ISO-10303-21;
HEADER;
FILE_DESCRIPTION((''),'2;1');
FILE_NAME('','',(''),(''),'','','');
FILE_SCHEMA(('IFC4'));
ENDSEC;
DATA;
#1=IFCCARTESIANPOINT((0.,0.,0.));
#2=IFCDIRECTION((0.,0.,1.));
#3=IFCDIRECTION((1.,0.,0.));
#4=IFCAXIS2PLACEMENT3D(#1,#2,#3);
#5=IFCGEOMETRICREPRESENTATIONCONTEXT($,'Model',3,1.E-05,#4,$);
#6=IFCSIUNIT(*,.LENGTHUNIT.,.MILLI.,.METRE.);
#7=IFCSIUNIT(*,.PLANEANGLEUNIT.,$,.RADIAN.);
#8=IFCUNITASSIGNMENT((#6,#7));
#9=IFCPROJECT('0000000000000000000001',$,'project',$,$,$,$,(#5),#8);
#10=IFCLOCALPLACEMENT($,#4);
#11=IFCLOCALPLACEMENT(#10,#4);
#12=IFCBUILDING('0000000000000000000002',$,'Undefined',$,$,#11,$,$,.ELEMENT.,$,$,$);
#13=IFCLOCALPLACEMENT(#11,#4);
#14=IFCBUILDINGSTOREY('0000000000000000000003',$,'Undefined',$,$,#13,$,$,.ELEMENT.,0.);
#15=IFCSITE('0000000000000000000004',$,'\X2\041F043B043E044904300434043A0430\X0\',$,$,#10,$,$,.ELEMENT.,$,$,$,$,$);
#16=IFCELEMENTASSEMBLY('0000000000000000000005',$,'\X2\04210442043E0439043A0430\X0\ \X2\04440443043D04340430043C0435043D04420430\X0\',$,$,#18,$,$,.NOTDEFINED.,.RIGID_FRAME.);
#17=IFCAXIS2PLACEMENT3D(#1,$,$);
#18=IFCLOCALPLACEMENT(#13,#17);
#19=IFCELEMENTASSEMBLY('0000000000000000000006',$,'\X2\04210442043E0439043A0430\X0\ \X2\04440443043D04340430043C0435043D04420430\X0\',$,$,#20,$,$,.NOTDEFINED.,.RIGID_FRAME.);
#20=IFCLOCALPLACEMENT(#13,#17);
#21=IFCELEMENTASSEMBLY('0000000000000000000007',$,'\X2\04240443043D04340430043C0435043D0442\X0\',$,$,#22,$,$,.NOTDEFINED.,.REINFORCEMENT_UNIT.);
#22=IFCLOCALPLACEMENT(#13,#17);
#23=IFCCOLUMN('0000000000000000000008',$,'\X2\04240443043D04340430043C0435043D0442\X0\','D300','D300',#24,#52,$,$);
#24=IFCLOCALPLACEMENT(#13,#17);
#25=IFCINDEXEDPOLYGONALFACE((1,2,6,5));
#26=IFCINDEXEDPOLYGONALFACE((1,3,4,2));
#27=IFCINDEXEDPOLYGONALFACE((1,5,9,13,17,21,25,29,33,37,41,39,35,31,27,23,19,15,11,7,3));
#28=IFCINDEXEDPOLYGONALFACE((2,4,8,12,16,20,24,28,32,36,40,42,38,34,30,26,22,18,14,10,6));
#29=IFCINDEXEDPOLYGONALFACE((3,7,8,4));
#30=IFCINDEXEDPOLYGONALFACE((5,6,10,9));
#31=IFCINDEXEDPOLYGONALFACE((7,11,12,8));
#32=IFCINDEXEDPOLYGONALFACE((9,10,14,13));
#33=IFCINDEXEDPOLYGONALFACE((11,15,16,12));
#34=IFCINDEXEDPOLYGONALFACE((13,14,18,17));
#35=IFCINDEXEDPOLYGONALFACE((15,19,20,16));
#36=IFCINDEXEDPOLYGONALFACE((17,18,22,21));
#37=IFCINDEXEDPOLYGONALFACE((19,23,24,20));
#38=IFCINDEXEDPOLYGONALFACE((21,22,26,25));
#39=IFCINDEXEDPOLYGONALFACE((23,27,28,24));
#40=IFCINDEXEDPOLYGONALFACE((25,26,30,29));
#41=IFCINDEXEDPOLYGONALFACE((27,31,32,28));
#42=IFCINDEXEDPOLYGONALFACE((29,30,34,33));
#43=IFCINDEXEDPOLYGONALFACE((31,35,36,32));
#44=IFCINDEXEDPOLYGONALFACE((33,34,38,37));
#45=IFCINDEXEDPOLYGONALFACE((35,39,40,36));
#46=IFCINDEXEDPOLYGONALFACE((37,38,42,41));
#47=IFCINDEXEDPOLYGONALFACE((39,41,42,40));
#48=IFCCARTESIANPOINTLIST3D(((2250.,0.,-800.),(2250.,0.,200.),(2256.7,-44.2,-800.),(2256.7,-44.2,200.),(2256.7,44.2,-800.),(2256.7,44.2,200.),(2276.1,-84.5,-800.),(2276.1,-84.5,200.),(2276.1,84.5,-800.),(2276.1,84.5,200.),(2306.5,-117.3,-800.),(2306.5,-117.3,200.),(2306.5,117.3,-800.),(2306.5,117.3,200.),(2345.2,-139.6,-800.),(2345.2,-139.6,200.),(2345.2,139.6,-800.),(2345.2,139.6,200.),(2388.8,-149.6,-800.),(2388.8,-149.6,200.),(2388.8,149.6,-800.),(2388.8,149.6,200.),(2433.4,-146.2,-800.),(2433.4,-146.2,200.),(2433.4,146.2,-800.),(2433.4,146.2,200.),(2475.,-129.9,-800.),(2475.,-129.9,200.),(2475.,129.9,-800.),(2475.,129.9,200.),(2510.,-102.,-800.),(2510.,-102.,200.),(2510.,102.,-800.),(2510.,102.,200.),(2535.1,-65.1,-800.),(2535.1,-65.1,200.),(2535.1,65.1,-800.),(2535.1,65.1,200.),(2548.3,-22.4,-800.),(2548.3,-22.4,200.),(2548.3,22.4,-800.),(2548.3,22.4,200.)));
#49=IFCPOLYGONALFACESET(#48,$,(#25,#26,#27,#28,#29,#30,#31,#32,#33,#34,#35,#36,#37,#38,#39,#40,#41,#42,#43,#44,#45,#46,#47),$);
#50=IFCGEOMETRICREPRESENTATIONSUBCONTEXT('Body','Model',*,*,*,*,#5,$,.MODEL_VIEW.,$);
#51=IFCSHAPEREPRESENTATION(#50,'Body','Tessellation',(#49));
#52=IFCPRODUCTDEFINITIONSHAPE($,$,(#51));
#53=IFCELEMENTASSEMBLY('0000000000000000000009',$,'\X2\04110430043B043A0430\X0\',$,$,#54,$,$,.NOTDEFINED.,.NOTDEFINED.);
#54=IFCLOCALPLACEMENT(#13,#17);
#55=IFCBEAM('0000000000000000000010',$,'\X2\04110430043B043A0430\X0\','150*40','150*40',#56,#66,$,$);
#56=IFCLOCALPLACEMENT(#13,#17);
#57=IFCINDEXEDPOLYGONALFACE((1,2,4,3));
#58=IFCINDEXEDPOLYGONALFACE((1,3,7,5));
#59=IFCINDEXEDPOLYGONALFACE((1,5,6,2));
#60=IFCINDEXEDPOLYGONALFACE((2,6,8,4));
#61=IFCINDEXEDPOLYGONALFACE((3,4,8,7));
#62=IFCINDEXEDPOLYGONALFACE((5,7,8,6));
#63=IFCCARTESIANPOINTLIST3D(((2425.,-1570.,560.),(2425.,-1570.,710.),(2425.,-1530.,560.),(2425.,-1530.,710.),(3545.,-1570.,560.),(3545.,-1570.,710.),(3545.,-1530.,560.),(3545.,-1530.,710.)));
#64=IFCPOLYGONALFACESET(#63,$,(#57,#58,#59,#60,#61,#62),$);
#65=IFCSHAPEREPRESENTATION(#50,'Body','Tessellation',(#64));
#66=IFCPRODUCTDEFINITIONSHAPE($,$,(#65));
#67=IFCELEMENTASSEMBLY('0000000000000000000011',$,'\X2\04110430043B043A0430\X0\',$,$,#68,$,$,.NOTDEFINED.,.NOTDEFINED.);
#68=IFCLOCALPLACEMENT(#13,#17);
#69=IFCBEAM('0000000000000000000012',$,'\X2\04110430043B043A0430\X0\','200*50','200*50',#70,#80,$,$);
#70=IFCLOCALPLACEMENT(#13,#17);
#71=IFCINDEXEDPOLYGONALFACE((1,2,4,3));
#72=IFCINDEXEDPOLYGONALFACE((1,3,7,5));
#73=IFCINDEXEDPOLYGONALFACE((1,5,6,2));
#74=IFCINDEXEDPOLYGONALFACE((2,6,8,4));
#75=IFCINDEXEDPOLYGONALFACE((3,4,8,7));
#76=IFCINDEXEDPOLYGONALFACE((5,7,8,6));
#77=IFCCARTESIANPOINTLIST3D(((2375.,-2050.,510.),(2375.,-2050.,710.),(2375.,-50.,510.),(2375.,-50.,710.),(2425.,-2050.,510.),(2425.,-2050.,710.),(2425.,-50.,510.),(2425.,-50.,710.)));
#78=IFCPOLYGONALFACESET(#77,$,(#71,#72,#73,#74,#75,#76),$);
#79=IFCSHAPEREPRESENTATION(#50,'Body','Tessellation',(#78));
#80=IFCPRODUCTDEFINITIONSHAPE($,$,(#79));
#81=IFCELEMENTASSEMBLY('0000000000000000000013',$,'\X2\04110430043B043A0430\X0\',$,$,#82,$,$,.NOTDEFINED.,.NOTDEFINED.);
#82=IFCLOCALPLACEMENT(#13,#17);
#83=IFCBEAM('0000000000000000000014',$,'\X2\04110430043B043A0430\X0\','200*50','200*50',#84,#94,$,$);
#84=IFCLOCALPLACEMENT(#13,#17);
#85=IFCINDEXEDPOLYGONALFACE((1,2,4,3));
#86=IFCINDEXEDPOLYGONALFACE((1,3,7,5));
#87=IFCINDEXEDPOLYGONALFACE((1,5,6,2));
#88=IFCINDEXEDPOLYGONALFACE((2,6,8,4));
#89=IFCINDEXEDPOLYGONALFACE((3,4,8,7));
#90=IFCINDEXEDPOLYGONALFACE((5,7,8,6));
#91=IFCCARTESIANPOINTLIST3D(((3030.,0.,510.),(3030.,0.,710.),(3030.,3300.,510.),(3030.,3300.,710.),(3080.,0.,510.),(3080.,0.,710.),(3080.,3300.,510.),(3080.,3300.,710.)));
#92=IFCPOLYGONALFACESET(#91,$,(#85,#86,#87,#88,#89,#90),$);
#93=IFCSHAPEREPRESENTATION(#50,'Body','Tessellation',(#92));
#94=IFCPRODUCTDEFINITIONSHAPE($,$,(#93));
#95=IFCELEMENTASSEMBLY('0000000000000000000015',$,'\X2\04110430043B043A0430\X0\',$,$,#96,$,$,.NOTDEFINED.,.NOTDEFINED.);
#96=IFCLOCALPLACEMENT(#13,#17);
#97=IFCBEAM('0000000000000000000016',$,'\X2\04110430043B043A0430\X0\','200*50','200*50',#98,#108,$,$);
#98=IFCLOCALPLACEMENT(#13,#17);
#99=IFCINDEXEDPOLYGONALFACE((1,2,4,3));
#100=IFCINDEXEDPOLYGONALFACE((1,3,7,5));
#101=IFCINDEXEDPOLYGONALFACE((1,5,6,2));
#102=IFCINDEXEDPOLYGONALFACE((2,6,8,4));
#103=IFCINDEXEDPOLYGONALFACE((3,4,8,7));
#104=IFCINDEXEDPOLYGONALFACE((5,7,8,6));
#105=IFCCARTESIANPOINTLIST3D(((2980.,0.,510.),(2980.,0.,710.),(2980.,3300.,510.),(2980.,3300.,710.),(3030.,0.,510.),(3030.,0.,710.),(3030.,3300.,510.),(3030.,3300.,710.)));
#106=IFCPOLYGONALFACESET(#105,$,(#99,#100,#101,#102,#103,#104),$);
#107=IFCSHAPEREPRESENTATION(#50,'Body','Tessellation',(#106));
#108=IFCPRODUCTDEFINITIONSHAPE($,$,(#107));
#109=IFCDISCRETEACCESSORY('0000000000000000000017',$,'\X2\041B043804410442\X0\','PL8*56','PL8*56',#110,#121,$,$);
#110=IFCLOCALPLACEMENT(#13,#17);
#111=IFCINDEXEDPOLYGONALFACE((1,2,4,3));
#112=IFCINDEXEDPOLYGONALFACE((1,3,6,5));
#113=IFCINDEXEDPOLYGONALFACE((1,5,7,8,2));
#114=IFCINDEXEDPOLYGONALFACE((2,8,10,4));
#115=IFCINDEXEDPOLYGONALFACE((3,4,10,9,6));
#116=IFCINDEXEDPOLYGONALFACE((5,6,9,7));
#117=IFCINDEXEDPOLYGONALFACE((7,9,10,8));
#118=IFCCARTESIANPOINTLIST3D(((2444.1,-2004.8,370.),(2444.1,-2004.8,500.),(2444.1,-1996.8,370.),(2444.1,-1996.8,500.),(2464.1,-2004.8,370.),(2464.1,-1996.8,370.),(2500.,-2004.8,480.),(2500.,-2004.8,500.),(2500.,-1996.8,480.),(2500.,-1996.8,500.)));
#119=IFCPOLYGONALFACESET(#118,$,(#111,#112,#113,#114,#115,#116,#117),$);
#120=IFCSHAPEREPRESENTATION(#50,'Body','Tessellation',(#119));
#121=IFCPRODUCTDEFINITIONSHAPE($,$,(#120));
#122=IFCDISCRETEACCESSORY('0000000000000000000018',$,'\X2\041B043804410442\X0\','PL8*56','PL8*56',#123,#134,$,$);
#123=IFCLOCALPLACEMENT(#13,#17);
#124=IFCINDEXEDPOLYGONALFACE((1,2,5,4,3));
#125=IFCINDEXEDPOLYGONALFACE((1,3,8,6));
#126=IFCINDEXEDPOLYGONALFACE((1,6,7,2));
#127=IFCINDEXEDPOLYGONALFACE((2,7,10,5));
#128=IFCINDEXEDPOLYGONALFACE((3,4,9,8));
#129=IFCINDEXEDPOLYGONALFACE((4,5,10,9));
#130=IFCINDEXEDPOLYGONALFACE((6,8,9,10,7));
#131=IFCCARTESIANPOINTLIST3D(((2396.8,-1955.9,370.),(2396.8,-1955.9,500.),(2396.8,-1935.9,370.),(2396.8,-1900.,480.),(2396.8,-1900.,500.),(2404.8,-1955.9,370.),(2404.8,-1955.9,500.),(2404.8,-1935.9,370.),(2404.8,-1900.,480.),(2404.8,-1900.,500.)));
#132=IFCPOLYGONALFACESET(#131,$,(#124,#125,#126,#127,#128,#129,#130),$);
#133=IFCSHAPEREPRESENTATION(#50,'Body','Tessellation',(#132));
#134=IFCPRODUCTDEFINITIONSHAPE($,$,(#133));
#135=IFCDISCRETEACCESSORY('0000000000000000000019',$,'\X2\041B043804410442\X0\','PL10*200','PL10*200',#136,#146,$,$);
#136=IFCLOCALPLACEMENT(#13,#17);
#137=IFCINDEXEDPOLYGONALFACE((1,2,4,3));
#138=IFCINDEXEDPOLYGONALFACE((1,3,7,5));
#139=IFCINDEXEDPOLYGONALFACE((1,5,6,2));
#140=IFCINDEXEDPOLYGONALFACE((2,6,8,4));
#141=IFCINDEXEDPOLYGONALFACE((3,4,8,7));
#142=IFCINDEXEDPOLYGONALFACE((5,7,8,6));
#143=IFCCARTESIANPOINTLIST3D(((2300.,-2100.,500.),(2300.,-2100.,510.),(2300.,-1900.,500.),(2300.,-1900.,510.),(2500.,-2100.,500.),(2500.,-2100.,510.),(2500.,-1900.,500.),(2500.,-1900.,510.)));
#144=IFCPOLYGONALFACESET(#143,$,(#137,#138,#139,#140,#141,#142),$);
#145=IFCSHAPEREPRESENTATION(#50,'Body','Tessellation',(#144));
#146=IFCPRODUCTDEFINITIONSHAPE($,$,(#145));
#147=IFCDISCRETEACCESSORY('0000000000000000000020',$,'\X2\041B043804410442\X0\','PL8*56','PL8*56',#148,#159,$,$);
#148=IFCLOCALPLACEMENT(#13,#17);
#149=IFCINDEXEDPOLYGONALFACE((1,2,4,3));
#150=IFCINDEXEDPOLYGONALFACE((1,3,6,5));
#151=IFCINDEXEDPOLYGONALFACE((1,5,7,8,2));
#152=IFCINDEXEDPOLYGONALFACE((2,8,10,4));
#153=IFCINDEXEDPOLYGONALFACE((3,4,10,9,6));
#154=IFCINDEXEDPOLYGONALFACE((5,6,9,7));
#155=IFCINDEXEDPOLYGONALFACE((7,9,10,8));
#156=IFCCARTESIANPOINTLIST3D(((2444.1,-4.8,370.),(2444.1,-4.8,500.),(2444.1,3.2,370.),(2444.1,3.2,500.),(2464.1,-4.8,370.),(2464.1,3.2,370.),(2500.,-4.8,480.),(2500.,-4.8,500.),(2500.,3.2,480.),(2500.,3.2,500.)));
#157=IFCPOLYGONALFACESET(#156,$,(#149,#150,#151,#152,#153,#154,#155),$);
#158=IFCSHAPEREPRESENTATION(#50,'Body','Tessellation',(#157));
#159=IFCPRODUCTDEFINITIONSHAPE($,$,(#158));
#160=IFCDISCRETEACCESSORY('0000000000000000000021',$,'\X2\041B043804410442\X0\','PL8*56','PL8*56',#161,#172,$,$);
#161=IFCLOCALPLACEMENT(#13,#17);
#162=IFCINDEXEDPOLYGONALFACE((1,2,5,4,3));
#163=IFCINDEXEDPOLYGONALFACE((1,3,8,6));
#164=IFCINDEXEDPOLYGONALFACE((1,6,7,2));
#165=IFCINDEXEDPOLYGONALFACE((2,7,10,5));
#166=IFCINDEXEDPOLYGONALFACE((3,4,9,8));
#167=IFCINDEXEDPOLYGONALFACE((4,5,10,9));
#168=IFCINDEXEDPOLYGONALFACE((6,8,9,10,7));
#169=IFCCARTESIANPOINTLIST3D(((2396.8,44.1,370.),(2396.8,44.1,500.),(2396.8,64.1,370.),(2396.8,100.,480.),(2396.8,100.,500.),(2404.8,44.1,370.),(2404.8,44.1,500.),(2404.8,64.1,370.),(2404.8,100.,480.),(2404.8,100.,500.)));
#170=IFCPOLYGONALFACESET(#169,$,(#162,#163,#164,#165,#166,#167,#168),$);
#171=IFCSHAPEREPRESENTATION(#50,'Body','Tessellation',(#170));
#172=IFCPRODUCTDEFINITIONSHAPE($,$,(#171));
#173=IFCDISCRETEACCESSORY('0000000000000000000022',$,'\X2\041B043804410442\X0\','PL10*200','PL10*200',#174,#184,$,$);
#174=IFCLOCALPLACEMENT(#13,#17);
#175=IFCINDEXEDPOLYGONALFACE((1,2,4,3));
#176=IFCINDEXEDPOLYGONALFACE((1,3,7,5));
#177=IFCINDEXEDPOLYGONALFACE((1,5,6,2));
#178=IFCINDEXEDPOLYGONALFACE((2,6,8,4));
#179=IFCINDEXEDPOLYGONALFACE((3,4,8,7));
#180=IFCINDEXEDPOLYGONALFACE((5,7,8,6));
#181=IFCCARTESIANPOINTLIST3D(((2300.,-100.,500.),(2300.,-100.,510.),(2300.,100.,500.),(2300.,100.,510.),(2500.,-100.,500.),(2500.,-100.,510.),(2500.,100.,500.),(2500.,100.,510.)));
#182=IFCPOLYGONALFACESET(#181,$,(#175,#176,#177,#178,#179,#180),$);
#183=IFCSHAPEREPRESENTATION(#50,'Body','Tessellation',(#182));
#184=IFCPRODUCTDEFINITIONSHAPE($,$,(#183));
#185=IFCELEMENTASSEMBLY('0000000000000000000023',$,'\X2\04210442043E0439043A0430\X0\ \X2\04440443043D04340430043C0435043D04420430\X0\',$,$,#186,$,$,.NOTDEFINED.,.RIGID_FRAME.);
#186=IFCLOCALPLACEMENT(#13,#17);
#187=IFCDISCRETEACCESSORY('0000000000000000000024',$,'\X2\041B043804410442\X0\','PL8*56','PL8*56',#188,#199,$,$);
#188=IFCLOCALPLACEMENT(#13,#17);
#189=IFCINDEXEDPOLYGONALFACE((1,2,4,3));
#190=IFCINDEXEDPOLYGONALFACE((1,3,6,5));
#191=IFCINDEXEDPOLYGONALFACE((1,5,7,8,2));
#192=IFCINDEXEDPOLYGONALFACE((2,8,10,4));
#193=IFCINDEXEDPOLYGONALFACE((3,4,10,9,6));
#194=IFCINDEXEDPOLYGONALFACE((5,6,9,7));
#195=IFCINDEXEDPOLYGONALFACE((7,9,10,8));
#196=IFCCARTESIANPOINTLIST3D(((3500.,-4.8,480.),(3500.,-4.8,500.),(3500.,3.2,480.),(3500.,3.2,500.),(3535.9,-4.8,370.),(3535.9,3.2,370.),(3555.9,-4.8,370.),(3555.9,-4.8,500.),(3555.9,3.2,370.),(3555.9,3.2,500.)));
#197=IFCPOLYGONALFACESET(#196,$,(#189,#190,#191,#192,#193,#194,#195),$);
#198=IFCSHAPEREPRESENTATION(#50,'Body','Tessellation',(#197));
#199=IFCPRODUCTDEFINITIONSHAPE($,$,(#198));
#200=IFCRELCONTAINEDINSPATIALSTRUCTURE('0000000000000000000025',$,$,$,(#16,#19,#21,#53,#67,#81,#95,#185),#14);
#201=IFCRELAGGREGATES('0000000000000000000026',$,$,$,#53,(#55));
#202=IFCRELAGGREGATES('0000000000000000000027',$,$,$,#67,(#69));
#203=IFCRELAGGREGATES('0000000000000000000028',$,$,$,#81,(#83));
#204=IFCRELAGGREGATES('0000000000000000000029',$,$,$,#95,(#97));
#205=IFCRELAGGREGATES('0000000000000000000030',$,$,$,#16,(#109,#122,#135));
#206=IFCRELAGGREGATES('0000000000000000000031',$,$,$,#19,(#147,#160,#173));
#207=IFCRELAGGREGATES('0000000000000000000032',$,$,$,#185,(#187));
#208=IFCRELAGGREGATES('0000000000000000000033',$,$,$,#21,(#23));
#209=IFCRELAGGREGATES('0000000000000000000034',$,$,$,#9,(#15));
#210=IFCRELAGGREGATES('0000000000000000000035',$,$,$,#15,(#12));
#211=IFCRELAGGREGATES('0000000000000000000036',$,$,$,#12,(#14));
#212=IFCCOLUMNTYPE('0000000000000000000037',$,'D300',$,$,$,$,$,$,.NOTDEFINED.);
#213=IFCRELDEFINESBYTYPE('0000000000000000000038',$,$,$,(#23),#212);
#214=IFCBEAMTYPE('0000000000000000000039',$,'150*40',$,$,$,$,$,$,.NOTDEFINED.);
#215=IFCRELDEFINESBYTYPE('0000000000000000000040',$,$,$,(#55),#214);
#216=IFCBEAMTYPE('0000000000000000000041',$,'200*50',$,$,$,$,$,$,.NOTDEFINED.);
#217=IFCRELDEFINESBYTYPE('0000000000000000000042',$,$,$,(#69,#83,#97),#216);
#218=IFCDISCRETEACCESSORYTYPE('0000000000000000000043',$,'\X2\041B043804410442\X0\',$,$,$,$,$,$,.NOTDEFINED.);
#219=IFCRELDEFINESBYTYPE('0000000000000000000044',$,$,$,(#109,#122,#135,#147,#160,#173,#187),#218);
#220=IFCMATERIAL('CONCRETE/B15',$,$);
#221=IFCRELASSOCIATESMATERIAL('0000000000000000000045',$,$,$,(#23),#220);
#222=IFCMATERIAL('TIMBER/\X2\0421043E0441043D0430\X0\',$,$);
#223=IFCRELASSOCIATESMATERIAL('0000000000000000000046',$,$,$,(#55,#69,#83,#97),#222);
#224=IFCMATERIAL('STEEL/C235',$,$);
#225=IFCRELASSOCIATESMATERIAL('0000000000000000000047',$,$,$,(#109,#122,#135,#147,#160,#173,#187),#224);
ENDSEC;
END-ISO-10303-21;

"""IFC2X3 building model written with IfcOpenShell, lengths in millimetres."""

from ifc_helpers import new_model, si_unit, frame, origin_with_axes, origin_2d_with_axis, place, context, subcontext, project, spatial, polyline, rectangle, circle, outline, extrude, material, type_object, element, aggregate, save


model = new_model("IFC2X3")

# Units and contexts
model_context = context("Model", 3, precision=1e-05, world=origin_with_axes())
body_context = subcontext(model_context, "Body", "Model", "MODEL_VIEW")
ifc_project = project(units=[si_unit("LENGTHUNIT", "METRE", prefix="MILLI"), si_unit("PLANEANGLEUNIT", "RADIAN")], contexts=[model_context])

# Site, building, storey
site_placement = place(None, origin_with_axes())
site = spatial("IfcSite", under=ifc_project, at=site_placement, Name="Площадка", CompositionType="ELEMENT")
building_placement = place(site_placement, origin_with_axes())
building = spatial("IfcBuilding", under=site, at=building_placement, Name="Undefined", CompositionType="ELEMENT")
storey_placement = place(building_placement, origin_with_axes())
storey = spatial("IfcBuildingStorey", under=building, at=storey_placement, Name="Undefined", CompositionType="ELEMENT", Elevation=0.0)

# Element assemblies, column
assembly_1_placement = place(storey_placement, origin_with_axes())
assembly_1 = element("IfcElementAssembly", 1, at=assembly_1_placement, inside=storey, Name="Стойка фундамента", AssemblyPlace="NOTDEFINED", PredefinedType="RIGID_FRAME")
ifc_material_1 = material(Name="STEEL/C235")
assembly_2_placement = place(storey_placement, origin_with_axes())
assembly_2 = element("IfcElementAssembly", 2, at=assembly_2_placement, inside=storey, Name="Стойка фундамента", AssemblyPlace="NOTDEFINED", PredefinedType="RIGID_FRAME")
ifc_material_2 = material(Name="CONCRETE/B15")
column_type_1 = type_object("IfcColumnType", Name="D300", PredefinedType="NOTDEFINED")
assembly_3_placement = place(storey_placement, origin_with_axes())
assembly_3 = element("IfcElementAssembly", 3, at=assembly_3_placement, inside=storey, Name="Фундамент", AssemblyPlace="NOTDEFINED", PredefinedType="REINFORCEMENT_UNIT")
column_1_placement = place(assembly_3_placement, frame((2400.0, 0.0, -800.0), z_axis=(0.0, 0.0, 1.0), x_axis=(0.0, 1.0, 0.0)))
column_1 = element("IfcColumn", 4, at=column_1_placement, type_object=column_type_1, material=ifc_material_2, Name="Фундамент", Description="D300", ObjectType="D300", context=body_context, shape_type="SweptSolid", body=[
    extrude(circle(Radius=150.0, at=origin_2d_with_axis()), frame((0.0, 0.0, 1000.0), z_axis=(0.0, 0.0, -1.0), x_axis=(0.0, 1.0, 0.0)), (0.0, 0.0, 1.0), 1000.0),
])

# Element assemblies, beams
assembly_4_placement = place(storey_placement, origin_with_axes())
assembly_4 = element("IfcElementAssembly", 5, at=assembly_4_placement, inside=storey, Name="Балка", AssemblyPlace="NOTDEFINED", PredefinedType="NOTDEFINED")
ifc_material_3 = material(Name="TIMBER/Сосна")
beam_type_1 = type_object("IfcBeamType", Name="150*40", PredefinedType="NOTDEFINED")
beam_1_placement = place(assembly_4_placement, frame((3545.0, -1550.0, 635.0), z_axis=(0.0, 0.0, -1.0), x_axis=(-1.0, 0.0, 0.0)))
beam_1 = element("IfcBeam", 6, at=beam_1_placement, type_object=beam_type_1, material=ifc_material_3, Name="Балка", Description="150*40", ObjectType="150*40", context=body_context, shape_type="SweptSolid", body=[
    extrude(rectangle(XDim=40.0, YDim=150.0, at=origin_2d_with_axis()), frame((1120.0, 0.0, 0.0), z_axis=(-1.0, 0.0, 0.0), x_axis=(0.0, -1.0, 0.0)), (0.0, 0.0, 1.0), 1120.0),
])
aggregate(assembly_4, [beam_1])
assembly_5_placement = place(storey_placement, origin_with_axes())
assembly_5 = element("IfcElementAssembly", 7, at=assembly_5_placement, inside=storey, Name="Балка", AssemblyPlace="NOTDEFINED", PredefinedType="NOTDEFINED")
beam_type_2 = type_object("IfcBeamType", Name="200*50", PredefinedType="NOTDEFINED")
beam_2_placement = place(assembly_5_placement, frame((2400.0, -2050.0, 610.0), z_axis=(0.0, 0.0, -1.0), x_axis=(0.0, 1.0, 0.0)))
beam_2 = element("IfcBeam", 8, at=beam_2_placement, type_object=beam_type_2, material=ifc_material_3, Name="Балка", Description="200*50", ObjectType="200*50", context=body_context, shape_type="SweptSolid", body=[
    extrude(rectangle(XDim=50.0, YDim=200.0, at=origin_2d_with_axis()), frame((2000.0, 0.0, 0.0), z_axis=(-1.0, 0.0, 0.0), x_axis=(0.0, -1.0, 0.0)), (0.0, 0.0, 1.0), 2000.0),
])
aggregate(assembly_5, [beam_2])
assembly_6_placement = place(storey_placement, origin_with_axes())
assembly_6 = element("IfcElementAssembly", 9, at=assembly_6_placement, inside=storey, Name="Балка", AssemblyPlace="NOTDEFINED", PredefinedType="NOTDEFINED")
beam_3_placement = place(assembly_6_placement, frame((3055.0, 0.0, 610.0), z_axis=(0.0, 0.0, -1.0), x_axis=(0.0, 1.0, 0.0)))
beam_3 = element("IfcBeam", 10, at=beam_3_placement, type_object=beam_type_2, material=ifc_material_3, Name="Балка", Description="200*50", ObjectType="200*50", context=body_context, shape_type="SweptSolid", body=[
    extrude(rectangle(XDim=50.0, YDim=200.0, at=origin_2d_with_axis()), frame((3300.0, 0.0, 0.0), z_axis=(-1.0, 0.0, 0.0), x_axis=(0.0, -1.0, 0.0)), (0.0, 0.0, 1.0), 3300.0),
])
aggregate(assembly_6, [beam_3])
assembly_7_placement = place(storey_placement, origin_with_axes())
assembly_7 = element("IfcElementAssembly", 11, at=assembly_7_placement, inside=storey, Name="Балка", AssemblyPlace="NOTDEFINED", PredefinedType="NOTDEFINED")
beam_4_placement = place(assembly_7_placement, frame((3005.0, 0.0, 610.0), z_axis=(0.0, 0.0, -1.0), x_axis=(0.0, 1.0, 0.0)))
beam_4 = element("IfcBeam", 12, at=beam_4_placement, type_object=beam_type_2, material=ifc_material_3, Name="Балка", Description="200*50", ObjectType="200*50", context=body_context, shape_type="SweptSolid", body=[
    extrude(rectangle(XDim=50.0, YDim=200.0, at=origin_2d_with_axis()), frame((3300.0, 0.0, 0.0), z_axis=(-1.0, 0.0, 0.0), x_axis=(0.0, -1.0, 0.0)), (0.0, 0.0, 1.0), 3300.0),
])
aggregate(assembly_7, [beam_4])

# Discrete accessories
discrete_accessory_type = type_object("IfcDiscreteAccessoryType", Name="Лист")
discrete_accessory_1_placement = place(assembly_1_placement, frame((2444.1, -2000.8, 500.0), z_axis=(0.0, 1.0, 0.0), x_axis=(1.0, 0.0, 0.0)))
discrete_accessory_1 = element("IfcDiscreteAccessory", 13, at=discrete_accessory_1_placement, type_object=discrete_accessory_type, material=ifc_material_1, Name="Лист", Description="PL8*56", ObjectType="PL8*56", context=body_context, shape_type="SweptSolid", body=[
    extrude(outline(polyline([(0.0, 0.0), (55.9, 0.0), (55.9, 20.0), (20.0, 130.0), (0.0, 130.0), (0.0, 0.0)])), frame((0.0, 0.0, -4.0), z_axis=(0.0, 0.0, 1.0), x_axis=(1.0, 0.0, 0.0)), (0.0, 0.0, 1.0), 8.0),
])
discrete_accessory_2_placement = place(assembly_1_placement, frame((2400.8, -1955.9, 500.0), z_axis=(-1.0, 0.0, 0.0), x_axis=(0.0, 1.0, 0.0)))
discrete_accessory_2 = element("IfcDiscreteAccessory", 14, at=discrete_accessory_2_placement, type_object=discrete_accessory_type, material=ifc_material_1, Name="Лист", Description="PL8*56", ObjectType="PL8*56", context=body_context, shape_type="SweptSolid", body=[
    extrude(outline(polyline([(0.0, 0.0), (55.9, 0.0), (55.9, 20.0), (20.0, 130.0), (0.0, 130.0), (0.0, 0.0)])), frame((0.0, 0.0, -4.0), z_axis=(0.0, 0.0, 1.0), x_axis=(1.0, 0.0, 0.0)), (0.0, 0.0, 1.0), 8.0),
])
discrete_accessory_3_placement = place(assembly_1_placement, frame((2500.0, -2100.0, 505.0), z_axis=(0.0, 0.0, -1.0), x_axis=(-1.0, 0.0, 0.0)))
discrete_accessory_3 = element("IfcDiscreteAccessory", 15, at=discrete_accessory_3_placement, type_object=discrete_accessory_type, material=ifc_material_1, Name="Лист", Description="PL10*200", ObjectType="PL10*200", context=body_context, shape_type="SweptSolid", body=[
    extrude(outline(polyline([(0.0, 0.0), (200.0, 0.0), (200.0, 200.0), (0.0, 200.0), (0.0, 0.0)])), frame((0.0, 0.0, -5.0), z_axis=(0.0, 0.0, 1.0), x_axis=(1.0, 0.0, 0.0)), (0.0, 0.0, 1.0), 10.0),
])
aggregate(assembly_1, [discrete_accessory_1, discrete_accessory_2, discrete_accessory_3])
discrete_accessory_4_placement = place(assembly_2_placement, frame((2444.1, -0.8, 500.0), z_axis=(0.0, 1.0, 0.0), x_axis=(1.0, 0.0, 0.0)))
discrete_accessory_4 = element("IfcDiscreteAccessory", 16, at=discrete_accessory_4_placement, type_object=discrete_accessory_type, material=ifc_material_1, Name="Лист", Description="PL8*56", ObjectType="PL8*56", context=body_context, shape_type="SweptSolid", body=[
    extrude(outline(polyline([(0.0, 0.0), (55.9, 0.0), (55.9, 20.0), (20.0, 130.0), (0.0, 130.0), (0.0, 0.0)])), frame((0.0, 0.0, -4.0), z_axis=(0.0, 0.0, 1.0), x_axis=(1.0, 0.0, 0.0)), (0.0, 0.0, 1.0), 8.0),
])
discrete_accessory_5_placement = place(assembly_2_placement, frame((2400.8, 44.1, 500.0), z_axis=(-1.0, 0.0, 0.0), x_axis=(0.0, 1.0, 0.0)))
discrete_accessory_5 = element("IfcDiscreteAccessory", 17, at=discrete_accessory_5_placement, type_object=discrete_accessory_type, material=ifc_material_1, Name="Лист", Description="PL8*56", ObjectType="PL8*56", context=body_context, shape_type="SweptSolid", body=[
    extrude(outline(polyline([(0.0, 0.0), (55.9, 0.0), (55.9, 20.0), (20.0, 130.0), (0.0, 130.0), (0.0, 0.0)])), frame((0.0, 0.0, -4.0), z_axis=(0.0, 0.0, 1.0), x_axis=(1.0, 0.0, 0.0)), (0.0, 0.0, 1.0), 8.0),
])
discrete_accessory_6_placement = place(assembly_2_placement, frame((2500.0, -100.0, 505.0), z_axis=(0.0, 0.0, -1.0), x_axis=(-1.0, 0.0, 0.0)))
discrete_accessory_6 = element("IfcDiscreteAccessory", 18, at=discrete_accessory_6_placement, type_object=discrete_accessory_type, material=ifc_material_1, Name="Лист", Description="PL10*200", ObjectType="PL10*200", context=body_context, shape_type="SweptSolid", body=[
    extrude(outline(polyline([(0.0, 0.0), (200.0, 0.0), (200.0, 200.0), (0.0, 200.0), (0.0, 0.0)])), frame((0.0, 0.0, -5.0), z_axis=(0.0, 0.0, 1.0), x_axis=(1.0, 0.0, 0.0)), (0.0, 0.0, 1.0), 10.0),
])
aggregate(assembly_2, [discrete_accessory_4, discrete_accessory_5, discrete_accessory_6])

# Element assembly, discrete accessory
assembly_8_placement = place(storey_placement, origin_with_axes())
assembly_8 = element("IfcElementAssembly", 19, at=assembly_8_placement, inside=storey, Name="Стойка фундамента", AssemblyPlace="NOTDEFINED", PredefinedType="RIGID_FRAME")
discrete_accessory_7_placement = place(assembly_8_placement, frame((3555.9, -0.8, 500.0), z_axis=(0.0, -1.0, 0.0), x_axis=(-1.0, 0.0, 0.0)))
discrete_accessory_7 = element("IfcDiscreteAccessory", 20, at=discrete_accessory_7_placement, type_object=discrete_accessory_type, material=ifc_material_1, Name="Лист", Description="PL8*56", ObjectType="PL8*56", context=body_context, shape_type="SweptSolid", body=[
    extrude(outline(polyline([(0.0, 0.0), (55.9, 0.0), (55.9, 20.0), (20.0, 130.0), (0.0, 130.0), (0.0, 0.0)])), frame((0.0, 0.0, -4.0), z_axis=(0.0, 0.0, 1.0), x_axis=(1.0, 0.0, 0.0)), (0.0, 0.0, 1.0), 8.0),
])
aggregate(assembly_8, [discrete_accessory_7])

aggregate(assembly_3, [column_1])

save(model, "model.ifc")
